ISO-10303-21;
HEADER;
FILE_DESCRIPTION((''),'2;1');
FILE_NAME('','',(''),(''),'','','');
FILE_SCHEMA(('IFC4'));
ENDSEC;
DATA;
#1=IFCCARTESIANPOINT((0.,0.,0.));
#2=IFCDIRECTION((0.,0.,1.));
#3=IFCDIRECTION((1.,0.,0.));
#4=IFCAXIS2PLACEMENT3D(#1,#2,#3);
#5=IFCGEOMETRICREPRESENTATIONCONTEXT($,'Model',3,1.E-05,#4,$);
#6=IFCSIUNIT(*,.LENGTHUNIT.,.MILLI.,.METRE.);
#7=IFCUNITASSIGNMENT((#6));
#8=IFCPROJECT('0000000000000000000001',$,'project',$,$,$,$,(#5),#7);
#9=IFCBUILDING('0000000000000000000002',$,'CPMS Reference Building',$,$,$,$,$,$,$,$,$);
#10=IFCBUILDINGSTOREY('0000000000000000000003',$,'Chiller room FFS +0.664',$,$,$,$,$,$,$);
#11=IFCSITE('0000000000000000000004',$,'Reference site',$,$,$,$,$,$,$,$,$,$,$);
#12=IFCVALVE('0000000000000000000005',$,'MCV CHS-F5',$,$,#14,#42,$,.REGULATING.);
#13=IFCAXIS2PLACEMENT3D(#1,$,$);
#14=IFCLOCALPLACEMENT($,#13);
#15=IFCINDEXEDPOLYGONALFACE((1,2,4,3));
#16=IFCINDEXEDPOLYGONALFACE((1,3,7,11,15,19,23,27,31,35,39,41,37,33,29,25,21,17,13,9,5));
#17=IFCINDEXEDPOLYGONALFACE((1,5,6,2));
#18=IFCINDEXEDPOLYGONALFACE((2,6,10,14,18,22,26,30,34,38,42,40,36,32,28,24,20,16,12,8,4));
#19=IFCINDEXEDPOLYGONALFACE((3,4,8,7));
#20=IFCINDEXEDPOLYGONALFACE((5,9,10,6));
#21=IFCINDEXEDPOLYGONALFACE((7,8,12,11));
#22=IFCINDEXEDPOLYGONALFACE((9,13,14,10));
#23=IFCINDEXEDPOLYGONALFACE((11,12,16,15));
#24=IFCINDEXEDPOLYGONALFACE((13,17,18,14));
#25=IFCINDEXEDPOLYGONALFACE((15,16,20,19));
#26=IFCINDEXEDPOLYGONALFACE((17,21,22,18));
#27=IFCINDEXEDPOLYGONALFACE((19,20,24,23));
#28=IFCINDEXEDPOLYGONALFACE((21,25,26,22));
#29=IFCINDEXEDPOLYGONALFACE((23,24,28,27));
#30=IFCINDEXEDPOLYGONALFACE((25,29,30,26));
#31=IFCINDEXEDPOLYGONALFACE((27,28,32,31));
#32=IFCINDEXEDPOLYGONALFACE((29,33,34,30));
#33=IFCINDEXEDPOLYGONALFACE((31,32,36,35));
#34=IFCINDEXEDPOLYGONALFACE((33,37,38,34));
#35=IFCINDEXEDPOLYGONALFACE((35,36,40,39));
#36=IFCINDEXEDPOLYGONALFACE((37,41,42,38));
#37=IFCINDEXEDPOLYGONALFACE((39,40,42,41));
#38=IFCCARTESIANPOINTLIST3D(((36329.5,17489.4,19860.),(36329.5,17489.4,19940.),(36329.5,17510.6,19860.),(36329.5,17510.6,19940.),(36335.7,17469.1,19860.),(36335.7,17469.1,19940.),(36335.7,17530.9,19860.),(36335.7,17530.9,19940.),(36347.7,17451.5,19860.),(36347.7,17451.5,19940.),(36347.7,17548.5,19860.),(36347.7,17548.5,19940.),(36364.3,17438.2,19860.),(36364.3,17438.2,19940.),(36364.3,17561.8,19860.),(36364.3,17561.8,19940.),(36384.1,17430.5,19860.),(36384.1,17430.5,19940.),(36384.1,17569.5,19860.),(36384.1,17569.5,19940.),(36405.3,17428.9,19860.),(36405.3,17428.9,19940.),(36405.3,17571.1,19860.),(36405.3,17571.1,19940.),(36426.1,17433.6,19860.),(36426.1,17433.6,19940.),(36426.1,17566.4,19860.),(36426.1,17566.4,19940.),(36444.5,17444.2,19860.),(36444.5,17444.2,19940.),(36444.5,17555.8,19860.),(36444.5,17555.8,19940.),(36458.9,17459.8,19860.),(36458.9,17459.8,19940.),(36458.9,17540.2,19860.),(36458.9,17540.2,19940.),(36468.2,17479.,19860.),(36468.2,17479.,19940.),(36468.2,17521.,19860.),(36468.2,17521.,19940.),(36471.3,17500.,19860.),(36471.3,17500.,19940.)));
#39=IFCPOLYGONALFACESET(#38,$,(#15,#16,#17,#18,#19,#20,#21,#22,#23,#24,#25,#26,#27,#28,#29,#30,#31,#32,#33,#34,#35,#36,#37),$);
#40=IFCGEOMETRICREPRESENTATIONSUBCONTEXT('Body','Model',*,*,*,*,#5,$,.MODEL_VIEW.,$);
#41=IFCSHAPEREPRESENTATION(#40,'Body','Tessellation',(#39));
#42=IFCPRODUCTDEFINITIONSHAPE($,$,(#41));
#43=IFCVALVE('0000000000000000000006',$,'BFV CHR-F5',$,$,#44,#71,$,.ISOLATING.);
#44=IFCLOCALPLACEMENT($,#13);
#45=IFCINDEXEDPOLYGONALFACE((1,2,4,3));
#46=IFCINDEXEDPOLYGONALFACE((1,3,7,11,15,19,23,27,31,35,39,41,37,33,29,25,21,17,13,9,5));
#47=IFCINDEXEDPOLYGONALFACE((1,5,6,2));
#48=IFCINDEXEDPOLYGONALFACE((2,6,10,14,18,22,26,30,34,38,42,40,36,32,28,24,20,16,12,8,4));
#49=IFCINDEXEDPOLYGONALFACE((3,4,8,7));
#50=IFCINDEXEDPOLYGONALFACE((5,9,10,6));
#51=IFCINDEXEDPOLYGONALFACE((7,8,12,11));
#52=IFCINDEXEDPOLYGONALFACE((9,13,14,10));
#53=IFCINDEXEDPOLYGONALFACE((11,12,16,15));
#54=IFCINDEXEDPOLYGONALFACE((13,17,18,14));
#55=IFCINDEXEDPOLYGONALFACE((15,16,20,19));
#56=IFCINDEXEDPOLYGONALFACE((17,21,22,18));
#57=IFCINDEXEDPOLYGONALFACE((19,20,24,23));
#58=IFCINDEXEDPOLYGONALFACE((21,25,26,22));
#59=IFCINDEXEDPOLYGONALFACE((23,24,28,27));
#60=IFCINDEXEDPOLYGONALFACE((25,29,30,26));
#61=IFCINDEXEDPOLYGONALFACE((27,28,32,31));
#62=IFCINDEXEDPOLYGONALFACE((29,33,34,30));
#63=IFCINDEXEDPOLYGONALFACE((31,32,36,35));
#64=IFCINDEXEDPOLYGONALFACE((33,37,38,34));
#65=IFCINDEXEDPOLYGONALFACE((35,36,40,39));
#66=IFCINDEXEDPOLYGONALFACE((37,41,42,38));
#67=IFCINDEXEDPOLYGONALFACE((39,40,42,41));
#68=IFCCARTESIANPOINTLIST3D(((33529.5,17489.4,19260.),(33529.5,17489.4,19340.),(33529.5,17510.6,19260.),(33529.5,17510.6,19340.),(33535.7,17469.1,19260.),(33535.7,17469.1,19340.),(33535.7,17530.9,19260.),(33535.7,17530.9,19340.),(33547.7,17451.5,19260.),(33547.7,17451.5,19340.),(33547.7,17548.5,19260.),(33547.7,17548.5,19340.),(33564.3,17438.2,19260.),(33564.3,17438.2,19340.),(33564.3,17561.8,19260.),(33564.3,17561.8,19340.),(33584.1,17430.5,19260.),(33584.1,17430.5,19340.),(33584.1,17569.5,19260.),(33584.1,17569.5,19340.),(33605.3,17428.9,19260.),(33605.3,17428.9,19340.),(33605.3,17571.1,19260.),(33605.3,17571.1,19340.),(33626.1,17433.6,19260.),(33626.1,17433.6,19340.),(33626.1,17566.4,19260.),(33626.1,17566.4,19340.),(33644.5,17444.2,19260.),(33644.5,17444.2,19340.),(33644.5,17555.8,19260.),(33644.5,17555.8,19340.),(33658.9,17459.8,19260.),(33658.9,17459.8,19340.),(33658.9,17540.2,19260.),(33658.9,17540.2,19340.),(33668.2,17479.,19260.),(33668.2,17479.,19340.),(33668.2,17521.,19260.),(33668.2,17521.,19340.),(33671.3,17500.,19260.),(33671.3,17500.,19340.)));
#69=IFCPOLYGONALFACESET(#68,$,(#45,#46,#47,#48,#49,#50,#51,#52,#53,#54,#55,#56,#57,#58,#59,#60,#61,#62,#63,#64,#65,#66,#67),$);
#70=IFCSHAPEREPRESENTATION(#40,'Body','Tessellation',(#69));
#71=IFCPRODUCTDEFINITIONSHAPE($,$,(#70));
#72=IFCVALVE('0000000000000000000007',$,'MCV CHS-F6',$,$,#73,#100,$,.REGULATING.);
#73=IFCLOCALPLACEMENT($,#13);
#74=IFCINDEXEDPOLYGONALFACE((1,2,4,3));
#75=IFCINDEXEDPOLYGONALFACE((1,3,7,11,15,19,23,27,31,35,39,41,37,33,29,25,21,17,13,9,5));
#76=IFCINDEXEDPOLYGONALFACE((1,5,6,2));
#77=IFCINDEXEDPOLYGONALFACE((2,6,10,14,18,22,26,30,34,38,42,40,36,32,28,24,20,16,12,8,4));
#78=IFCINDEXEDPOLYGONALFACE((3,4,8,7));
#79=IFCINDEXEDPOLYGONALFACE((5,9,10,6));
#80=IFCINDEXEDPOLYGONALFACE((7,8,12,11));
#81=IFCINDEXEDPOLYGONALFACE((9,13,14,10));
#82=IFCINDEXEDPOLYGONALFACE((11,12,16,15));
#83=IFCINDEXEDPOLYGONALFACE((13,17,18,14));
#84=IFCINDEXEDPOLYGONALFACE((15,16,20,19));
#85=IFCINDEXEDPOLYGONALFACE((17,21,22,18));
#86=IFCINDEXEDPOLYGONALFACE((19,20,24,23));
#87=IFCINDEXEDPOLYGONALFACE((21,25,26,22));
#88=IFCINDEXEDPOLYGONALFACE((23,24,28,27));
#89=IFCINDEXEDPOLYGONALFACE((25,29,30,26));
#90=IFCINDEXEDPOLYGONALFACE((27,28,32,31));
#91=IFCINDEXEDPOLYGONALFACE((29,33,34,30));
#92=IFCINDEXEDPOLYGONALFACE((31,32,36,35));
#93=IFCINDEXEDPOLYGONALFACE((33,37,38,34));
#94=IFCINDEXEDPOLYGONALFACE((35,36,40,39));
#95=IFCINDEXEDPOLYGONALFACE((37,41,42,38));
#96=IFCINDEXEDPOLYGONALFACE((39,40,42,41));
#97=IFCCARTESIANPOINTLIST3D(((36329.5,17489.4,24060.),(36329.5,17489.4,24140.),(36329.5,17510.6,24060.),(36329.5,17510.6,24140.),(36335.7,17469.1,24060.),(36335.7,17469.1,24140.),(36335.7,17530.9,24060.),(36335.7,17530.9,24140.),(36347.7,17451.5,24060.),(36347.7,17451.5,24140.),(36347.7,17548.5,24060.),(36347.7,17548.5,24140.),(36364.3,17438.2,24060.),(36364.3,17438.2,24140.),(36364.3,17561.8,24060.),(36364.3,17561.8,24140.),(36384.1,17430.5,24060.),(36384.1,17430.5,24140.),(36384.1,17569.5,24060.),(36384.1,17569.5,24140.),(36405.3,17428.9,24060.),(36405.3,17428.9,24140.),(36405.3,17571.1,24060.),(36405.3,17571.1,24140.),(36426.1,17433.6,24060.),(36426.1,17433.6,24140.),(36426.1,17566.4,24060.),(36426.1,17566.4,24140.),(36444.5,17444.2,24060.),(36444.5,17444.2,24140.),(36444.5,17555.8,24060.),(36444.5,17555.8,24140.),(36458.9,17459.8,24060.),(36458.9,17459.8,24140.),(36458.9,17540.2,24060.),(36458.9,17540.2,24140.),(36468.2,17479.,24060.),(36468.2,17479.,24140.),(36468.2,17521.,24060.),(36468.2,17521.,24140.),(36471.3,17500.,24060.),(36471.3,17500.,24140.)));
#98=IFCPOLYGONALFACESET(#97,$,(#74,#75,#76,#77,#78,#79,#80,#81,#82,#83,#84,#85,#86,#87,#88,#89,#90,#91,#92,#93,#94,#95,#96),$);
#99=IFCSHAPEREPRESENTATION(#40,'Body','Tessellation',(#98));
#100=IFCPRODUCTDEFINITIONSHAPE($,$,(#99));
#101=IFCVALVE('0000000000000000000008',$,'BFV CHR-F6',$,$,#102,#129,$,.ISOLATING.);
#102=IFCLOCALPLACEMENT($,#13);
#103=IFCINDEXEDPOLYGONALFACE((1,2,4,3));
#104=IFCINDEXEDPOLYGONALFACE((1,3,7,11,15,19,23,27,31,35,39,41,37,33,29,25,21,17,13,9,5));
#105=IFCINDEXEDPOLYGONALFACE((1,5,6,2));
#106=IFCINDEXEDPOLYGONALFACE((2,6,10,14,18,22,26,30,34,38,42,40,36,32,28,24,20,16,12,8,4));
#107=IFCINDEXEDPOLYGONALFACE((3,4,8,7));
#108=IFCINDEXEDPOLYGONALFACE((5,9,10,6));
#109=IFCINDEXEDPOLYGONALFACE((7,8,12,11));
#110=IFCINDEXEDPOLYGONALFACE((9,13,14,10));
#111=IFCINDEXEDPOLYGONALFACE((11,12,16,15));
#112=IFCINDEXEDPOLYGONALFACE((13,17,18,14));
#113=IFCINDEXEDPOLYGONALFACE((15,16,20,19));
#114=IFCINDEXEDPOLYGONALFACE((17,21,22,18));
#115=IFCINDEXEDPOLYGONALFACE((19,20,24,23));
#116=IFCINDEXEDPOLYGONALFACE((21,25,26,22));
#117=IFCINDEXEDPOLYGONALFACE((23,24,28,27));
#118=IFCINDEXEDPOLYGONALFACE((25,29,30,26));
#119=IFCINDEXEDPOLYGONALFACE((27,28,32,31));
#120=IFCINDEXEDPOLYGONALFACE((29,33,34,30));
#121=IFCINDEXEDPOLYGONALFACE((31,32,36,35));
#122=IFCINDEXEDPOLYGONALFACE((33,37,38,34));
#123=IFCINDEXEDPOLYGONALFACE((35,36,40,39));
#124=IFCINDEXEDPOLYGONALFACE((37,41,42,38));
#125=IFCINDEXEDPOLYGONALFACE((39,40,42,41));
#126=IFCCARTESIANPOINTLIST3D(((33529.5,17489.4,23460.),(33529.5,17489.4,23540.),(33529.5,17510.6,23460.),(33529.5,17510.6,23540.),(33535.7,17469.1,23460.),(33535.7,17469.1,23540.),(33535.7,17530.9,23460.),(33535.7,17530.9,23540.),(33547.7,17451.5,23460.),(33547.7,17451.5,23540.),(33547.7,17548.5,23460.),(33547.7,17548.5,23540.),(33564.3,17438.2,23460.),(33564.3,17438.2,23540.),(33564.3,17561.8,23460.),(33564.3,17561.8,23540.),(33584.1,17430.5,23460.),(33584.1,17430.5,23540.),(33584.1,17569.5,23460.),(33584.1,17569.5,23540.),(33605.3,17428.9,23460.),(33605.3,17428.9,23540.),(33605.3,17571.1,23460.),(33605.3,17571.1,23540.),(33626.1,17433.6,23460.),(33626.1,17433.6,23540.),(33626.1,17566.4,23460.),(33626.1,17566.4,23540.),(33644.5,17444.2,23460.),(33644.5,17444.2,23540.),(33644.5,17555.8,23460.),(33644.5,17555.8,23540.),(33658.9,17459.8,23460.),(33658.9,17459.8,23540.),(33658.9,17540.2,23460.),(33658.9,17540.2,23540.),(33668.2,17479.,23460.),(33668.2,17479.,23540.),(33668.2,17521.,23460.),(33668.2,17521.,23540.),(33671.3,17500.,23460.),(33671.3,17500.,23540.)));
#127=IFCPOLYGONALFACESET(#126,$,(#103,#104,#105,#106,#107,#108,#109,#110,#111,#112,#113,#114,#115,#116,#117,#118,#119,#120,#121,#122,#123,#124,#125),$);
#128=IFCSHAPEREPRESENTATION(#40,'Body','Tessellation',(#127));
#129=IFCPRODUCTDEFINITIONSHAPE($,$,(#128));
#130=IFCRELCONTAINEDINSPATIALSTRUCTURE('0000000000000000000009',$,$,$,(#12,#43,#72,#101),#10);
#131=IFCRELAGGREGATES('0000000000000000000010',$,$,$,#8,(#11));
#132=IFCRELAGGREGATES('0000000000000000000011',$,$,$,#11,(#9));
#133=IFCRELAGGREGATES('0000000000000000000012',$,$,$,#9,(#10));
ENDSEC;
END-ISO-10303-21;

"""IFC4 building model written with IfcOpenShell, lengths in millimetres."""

from ifc_helpers import new_model, si_unit, frame, origin_with_axes, origin_2d, place, context, subcontext, project, spatial, circle_curve, outline, extrude, element, save


model = new_model("IFC4")

# Units and contexts
model_context = context("Model", 3, precision=1e-05, world=origin_with_axes())
body_context = subcontext(model_context, "Body", "Model", "MODEL_VIEW")
ifc_project = project(units=[si_unit("LENGTHUNIT", "METRE", prefix="MILLI")], contexts=[model_context])

# Site, building, storey
site = spatial("IfcSite", under=ifc_project, Name="Reference site")
building = spatial("IfcBuilding", under=site, Name="CPMS Reference Building")
storey = spatial("IfcBuildingStorey", under=building, Name="Chiller room FFS +0.664")

# Valves
valve_1_placement = place(None, origin_with_axes())
element("IfcValve", 1, at=valve_1_placement, inside=storey, Name="MCV CHS-F5", PredefinedType="REGULATING", context=body_context, shape_type="SweptSolid", body=[
    extrude(outline(circle_curve(origin_2d(), 71.3)), frame((36400.0, 17500.0, 19940.0), z_axis=(0.0, 0.0, -1.0), x_axis=(1.0, 0.0, 0.0)), (0.0, 0.0, 1.0), 80.0),
])
valve_2_placement = place(None, origin_with_axes())
element("IfcValve", 2, at=valve_2_placement, inside=storey, Name="BFV CHR-F5", PredefinedType="ISOLATING", context=body_context, shape_type="SweptSolid", body=[
    extrude(outline(circle_curve(origin_2d(), 71.3)), frame((33600.0, 17500.0, 19260.0), z_axis=(0.0, 0.0, 1.0), x_axis=(1.0, 0.0, 0.0)), (0.0, 0.0, 1.0), 80.0),
])
valve_3_placement = place(None, origin_with_axes())
element("IfcValve", 3, at=valve_3_placement, inside=storey, Name="MCV CHS-F6", PredefinedType="REGULATING", context=body_context, shape_type="SweptSolid", body=[
    extrude(outline(circle_curve(origin_2d(), 71.3)), frame((36400.0, 17500.0, 24140.0), z_axis=(0.0, 0.0, -1.0), x_axis=(1.0, 0.0, 0.0)), (0.0, 0.0, 1.0), 80.0),
])
valve_4_placement = place(None, origin_with_axes())
element("IfcValve", 4, at=valve_4_placement, inside=storey, Name="BFV CHR-F6", PredefinedType="ISOLATING", context=body_context, shape_type="SweptSolid", body=[
    extrude(outline(circle_curve(origin_2d(), 71.3)), frame((33600.0, 17500.0, 23460.0), z_axis=(0.0, 0.0, 1.0), x_axis=(1.0, 0.0, 0.0)), (0.0, 0.0, 1.0), 80.0),
])

save(model, "model.ifc")
